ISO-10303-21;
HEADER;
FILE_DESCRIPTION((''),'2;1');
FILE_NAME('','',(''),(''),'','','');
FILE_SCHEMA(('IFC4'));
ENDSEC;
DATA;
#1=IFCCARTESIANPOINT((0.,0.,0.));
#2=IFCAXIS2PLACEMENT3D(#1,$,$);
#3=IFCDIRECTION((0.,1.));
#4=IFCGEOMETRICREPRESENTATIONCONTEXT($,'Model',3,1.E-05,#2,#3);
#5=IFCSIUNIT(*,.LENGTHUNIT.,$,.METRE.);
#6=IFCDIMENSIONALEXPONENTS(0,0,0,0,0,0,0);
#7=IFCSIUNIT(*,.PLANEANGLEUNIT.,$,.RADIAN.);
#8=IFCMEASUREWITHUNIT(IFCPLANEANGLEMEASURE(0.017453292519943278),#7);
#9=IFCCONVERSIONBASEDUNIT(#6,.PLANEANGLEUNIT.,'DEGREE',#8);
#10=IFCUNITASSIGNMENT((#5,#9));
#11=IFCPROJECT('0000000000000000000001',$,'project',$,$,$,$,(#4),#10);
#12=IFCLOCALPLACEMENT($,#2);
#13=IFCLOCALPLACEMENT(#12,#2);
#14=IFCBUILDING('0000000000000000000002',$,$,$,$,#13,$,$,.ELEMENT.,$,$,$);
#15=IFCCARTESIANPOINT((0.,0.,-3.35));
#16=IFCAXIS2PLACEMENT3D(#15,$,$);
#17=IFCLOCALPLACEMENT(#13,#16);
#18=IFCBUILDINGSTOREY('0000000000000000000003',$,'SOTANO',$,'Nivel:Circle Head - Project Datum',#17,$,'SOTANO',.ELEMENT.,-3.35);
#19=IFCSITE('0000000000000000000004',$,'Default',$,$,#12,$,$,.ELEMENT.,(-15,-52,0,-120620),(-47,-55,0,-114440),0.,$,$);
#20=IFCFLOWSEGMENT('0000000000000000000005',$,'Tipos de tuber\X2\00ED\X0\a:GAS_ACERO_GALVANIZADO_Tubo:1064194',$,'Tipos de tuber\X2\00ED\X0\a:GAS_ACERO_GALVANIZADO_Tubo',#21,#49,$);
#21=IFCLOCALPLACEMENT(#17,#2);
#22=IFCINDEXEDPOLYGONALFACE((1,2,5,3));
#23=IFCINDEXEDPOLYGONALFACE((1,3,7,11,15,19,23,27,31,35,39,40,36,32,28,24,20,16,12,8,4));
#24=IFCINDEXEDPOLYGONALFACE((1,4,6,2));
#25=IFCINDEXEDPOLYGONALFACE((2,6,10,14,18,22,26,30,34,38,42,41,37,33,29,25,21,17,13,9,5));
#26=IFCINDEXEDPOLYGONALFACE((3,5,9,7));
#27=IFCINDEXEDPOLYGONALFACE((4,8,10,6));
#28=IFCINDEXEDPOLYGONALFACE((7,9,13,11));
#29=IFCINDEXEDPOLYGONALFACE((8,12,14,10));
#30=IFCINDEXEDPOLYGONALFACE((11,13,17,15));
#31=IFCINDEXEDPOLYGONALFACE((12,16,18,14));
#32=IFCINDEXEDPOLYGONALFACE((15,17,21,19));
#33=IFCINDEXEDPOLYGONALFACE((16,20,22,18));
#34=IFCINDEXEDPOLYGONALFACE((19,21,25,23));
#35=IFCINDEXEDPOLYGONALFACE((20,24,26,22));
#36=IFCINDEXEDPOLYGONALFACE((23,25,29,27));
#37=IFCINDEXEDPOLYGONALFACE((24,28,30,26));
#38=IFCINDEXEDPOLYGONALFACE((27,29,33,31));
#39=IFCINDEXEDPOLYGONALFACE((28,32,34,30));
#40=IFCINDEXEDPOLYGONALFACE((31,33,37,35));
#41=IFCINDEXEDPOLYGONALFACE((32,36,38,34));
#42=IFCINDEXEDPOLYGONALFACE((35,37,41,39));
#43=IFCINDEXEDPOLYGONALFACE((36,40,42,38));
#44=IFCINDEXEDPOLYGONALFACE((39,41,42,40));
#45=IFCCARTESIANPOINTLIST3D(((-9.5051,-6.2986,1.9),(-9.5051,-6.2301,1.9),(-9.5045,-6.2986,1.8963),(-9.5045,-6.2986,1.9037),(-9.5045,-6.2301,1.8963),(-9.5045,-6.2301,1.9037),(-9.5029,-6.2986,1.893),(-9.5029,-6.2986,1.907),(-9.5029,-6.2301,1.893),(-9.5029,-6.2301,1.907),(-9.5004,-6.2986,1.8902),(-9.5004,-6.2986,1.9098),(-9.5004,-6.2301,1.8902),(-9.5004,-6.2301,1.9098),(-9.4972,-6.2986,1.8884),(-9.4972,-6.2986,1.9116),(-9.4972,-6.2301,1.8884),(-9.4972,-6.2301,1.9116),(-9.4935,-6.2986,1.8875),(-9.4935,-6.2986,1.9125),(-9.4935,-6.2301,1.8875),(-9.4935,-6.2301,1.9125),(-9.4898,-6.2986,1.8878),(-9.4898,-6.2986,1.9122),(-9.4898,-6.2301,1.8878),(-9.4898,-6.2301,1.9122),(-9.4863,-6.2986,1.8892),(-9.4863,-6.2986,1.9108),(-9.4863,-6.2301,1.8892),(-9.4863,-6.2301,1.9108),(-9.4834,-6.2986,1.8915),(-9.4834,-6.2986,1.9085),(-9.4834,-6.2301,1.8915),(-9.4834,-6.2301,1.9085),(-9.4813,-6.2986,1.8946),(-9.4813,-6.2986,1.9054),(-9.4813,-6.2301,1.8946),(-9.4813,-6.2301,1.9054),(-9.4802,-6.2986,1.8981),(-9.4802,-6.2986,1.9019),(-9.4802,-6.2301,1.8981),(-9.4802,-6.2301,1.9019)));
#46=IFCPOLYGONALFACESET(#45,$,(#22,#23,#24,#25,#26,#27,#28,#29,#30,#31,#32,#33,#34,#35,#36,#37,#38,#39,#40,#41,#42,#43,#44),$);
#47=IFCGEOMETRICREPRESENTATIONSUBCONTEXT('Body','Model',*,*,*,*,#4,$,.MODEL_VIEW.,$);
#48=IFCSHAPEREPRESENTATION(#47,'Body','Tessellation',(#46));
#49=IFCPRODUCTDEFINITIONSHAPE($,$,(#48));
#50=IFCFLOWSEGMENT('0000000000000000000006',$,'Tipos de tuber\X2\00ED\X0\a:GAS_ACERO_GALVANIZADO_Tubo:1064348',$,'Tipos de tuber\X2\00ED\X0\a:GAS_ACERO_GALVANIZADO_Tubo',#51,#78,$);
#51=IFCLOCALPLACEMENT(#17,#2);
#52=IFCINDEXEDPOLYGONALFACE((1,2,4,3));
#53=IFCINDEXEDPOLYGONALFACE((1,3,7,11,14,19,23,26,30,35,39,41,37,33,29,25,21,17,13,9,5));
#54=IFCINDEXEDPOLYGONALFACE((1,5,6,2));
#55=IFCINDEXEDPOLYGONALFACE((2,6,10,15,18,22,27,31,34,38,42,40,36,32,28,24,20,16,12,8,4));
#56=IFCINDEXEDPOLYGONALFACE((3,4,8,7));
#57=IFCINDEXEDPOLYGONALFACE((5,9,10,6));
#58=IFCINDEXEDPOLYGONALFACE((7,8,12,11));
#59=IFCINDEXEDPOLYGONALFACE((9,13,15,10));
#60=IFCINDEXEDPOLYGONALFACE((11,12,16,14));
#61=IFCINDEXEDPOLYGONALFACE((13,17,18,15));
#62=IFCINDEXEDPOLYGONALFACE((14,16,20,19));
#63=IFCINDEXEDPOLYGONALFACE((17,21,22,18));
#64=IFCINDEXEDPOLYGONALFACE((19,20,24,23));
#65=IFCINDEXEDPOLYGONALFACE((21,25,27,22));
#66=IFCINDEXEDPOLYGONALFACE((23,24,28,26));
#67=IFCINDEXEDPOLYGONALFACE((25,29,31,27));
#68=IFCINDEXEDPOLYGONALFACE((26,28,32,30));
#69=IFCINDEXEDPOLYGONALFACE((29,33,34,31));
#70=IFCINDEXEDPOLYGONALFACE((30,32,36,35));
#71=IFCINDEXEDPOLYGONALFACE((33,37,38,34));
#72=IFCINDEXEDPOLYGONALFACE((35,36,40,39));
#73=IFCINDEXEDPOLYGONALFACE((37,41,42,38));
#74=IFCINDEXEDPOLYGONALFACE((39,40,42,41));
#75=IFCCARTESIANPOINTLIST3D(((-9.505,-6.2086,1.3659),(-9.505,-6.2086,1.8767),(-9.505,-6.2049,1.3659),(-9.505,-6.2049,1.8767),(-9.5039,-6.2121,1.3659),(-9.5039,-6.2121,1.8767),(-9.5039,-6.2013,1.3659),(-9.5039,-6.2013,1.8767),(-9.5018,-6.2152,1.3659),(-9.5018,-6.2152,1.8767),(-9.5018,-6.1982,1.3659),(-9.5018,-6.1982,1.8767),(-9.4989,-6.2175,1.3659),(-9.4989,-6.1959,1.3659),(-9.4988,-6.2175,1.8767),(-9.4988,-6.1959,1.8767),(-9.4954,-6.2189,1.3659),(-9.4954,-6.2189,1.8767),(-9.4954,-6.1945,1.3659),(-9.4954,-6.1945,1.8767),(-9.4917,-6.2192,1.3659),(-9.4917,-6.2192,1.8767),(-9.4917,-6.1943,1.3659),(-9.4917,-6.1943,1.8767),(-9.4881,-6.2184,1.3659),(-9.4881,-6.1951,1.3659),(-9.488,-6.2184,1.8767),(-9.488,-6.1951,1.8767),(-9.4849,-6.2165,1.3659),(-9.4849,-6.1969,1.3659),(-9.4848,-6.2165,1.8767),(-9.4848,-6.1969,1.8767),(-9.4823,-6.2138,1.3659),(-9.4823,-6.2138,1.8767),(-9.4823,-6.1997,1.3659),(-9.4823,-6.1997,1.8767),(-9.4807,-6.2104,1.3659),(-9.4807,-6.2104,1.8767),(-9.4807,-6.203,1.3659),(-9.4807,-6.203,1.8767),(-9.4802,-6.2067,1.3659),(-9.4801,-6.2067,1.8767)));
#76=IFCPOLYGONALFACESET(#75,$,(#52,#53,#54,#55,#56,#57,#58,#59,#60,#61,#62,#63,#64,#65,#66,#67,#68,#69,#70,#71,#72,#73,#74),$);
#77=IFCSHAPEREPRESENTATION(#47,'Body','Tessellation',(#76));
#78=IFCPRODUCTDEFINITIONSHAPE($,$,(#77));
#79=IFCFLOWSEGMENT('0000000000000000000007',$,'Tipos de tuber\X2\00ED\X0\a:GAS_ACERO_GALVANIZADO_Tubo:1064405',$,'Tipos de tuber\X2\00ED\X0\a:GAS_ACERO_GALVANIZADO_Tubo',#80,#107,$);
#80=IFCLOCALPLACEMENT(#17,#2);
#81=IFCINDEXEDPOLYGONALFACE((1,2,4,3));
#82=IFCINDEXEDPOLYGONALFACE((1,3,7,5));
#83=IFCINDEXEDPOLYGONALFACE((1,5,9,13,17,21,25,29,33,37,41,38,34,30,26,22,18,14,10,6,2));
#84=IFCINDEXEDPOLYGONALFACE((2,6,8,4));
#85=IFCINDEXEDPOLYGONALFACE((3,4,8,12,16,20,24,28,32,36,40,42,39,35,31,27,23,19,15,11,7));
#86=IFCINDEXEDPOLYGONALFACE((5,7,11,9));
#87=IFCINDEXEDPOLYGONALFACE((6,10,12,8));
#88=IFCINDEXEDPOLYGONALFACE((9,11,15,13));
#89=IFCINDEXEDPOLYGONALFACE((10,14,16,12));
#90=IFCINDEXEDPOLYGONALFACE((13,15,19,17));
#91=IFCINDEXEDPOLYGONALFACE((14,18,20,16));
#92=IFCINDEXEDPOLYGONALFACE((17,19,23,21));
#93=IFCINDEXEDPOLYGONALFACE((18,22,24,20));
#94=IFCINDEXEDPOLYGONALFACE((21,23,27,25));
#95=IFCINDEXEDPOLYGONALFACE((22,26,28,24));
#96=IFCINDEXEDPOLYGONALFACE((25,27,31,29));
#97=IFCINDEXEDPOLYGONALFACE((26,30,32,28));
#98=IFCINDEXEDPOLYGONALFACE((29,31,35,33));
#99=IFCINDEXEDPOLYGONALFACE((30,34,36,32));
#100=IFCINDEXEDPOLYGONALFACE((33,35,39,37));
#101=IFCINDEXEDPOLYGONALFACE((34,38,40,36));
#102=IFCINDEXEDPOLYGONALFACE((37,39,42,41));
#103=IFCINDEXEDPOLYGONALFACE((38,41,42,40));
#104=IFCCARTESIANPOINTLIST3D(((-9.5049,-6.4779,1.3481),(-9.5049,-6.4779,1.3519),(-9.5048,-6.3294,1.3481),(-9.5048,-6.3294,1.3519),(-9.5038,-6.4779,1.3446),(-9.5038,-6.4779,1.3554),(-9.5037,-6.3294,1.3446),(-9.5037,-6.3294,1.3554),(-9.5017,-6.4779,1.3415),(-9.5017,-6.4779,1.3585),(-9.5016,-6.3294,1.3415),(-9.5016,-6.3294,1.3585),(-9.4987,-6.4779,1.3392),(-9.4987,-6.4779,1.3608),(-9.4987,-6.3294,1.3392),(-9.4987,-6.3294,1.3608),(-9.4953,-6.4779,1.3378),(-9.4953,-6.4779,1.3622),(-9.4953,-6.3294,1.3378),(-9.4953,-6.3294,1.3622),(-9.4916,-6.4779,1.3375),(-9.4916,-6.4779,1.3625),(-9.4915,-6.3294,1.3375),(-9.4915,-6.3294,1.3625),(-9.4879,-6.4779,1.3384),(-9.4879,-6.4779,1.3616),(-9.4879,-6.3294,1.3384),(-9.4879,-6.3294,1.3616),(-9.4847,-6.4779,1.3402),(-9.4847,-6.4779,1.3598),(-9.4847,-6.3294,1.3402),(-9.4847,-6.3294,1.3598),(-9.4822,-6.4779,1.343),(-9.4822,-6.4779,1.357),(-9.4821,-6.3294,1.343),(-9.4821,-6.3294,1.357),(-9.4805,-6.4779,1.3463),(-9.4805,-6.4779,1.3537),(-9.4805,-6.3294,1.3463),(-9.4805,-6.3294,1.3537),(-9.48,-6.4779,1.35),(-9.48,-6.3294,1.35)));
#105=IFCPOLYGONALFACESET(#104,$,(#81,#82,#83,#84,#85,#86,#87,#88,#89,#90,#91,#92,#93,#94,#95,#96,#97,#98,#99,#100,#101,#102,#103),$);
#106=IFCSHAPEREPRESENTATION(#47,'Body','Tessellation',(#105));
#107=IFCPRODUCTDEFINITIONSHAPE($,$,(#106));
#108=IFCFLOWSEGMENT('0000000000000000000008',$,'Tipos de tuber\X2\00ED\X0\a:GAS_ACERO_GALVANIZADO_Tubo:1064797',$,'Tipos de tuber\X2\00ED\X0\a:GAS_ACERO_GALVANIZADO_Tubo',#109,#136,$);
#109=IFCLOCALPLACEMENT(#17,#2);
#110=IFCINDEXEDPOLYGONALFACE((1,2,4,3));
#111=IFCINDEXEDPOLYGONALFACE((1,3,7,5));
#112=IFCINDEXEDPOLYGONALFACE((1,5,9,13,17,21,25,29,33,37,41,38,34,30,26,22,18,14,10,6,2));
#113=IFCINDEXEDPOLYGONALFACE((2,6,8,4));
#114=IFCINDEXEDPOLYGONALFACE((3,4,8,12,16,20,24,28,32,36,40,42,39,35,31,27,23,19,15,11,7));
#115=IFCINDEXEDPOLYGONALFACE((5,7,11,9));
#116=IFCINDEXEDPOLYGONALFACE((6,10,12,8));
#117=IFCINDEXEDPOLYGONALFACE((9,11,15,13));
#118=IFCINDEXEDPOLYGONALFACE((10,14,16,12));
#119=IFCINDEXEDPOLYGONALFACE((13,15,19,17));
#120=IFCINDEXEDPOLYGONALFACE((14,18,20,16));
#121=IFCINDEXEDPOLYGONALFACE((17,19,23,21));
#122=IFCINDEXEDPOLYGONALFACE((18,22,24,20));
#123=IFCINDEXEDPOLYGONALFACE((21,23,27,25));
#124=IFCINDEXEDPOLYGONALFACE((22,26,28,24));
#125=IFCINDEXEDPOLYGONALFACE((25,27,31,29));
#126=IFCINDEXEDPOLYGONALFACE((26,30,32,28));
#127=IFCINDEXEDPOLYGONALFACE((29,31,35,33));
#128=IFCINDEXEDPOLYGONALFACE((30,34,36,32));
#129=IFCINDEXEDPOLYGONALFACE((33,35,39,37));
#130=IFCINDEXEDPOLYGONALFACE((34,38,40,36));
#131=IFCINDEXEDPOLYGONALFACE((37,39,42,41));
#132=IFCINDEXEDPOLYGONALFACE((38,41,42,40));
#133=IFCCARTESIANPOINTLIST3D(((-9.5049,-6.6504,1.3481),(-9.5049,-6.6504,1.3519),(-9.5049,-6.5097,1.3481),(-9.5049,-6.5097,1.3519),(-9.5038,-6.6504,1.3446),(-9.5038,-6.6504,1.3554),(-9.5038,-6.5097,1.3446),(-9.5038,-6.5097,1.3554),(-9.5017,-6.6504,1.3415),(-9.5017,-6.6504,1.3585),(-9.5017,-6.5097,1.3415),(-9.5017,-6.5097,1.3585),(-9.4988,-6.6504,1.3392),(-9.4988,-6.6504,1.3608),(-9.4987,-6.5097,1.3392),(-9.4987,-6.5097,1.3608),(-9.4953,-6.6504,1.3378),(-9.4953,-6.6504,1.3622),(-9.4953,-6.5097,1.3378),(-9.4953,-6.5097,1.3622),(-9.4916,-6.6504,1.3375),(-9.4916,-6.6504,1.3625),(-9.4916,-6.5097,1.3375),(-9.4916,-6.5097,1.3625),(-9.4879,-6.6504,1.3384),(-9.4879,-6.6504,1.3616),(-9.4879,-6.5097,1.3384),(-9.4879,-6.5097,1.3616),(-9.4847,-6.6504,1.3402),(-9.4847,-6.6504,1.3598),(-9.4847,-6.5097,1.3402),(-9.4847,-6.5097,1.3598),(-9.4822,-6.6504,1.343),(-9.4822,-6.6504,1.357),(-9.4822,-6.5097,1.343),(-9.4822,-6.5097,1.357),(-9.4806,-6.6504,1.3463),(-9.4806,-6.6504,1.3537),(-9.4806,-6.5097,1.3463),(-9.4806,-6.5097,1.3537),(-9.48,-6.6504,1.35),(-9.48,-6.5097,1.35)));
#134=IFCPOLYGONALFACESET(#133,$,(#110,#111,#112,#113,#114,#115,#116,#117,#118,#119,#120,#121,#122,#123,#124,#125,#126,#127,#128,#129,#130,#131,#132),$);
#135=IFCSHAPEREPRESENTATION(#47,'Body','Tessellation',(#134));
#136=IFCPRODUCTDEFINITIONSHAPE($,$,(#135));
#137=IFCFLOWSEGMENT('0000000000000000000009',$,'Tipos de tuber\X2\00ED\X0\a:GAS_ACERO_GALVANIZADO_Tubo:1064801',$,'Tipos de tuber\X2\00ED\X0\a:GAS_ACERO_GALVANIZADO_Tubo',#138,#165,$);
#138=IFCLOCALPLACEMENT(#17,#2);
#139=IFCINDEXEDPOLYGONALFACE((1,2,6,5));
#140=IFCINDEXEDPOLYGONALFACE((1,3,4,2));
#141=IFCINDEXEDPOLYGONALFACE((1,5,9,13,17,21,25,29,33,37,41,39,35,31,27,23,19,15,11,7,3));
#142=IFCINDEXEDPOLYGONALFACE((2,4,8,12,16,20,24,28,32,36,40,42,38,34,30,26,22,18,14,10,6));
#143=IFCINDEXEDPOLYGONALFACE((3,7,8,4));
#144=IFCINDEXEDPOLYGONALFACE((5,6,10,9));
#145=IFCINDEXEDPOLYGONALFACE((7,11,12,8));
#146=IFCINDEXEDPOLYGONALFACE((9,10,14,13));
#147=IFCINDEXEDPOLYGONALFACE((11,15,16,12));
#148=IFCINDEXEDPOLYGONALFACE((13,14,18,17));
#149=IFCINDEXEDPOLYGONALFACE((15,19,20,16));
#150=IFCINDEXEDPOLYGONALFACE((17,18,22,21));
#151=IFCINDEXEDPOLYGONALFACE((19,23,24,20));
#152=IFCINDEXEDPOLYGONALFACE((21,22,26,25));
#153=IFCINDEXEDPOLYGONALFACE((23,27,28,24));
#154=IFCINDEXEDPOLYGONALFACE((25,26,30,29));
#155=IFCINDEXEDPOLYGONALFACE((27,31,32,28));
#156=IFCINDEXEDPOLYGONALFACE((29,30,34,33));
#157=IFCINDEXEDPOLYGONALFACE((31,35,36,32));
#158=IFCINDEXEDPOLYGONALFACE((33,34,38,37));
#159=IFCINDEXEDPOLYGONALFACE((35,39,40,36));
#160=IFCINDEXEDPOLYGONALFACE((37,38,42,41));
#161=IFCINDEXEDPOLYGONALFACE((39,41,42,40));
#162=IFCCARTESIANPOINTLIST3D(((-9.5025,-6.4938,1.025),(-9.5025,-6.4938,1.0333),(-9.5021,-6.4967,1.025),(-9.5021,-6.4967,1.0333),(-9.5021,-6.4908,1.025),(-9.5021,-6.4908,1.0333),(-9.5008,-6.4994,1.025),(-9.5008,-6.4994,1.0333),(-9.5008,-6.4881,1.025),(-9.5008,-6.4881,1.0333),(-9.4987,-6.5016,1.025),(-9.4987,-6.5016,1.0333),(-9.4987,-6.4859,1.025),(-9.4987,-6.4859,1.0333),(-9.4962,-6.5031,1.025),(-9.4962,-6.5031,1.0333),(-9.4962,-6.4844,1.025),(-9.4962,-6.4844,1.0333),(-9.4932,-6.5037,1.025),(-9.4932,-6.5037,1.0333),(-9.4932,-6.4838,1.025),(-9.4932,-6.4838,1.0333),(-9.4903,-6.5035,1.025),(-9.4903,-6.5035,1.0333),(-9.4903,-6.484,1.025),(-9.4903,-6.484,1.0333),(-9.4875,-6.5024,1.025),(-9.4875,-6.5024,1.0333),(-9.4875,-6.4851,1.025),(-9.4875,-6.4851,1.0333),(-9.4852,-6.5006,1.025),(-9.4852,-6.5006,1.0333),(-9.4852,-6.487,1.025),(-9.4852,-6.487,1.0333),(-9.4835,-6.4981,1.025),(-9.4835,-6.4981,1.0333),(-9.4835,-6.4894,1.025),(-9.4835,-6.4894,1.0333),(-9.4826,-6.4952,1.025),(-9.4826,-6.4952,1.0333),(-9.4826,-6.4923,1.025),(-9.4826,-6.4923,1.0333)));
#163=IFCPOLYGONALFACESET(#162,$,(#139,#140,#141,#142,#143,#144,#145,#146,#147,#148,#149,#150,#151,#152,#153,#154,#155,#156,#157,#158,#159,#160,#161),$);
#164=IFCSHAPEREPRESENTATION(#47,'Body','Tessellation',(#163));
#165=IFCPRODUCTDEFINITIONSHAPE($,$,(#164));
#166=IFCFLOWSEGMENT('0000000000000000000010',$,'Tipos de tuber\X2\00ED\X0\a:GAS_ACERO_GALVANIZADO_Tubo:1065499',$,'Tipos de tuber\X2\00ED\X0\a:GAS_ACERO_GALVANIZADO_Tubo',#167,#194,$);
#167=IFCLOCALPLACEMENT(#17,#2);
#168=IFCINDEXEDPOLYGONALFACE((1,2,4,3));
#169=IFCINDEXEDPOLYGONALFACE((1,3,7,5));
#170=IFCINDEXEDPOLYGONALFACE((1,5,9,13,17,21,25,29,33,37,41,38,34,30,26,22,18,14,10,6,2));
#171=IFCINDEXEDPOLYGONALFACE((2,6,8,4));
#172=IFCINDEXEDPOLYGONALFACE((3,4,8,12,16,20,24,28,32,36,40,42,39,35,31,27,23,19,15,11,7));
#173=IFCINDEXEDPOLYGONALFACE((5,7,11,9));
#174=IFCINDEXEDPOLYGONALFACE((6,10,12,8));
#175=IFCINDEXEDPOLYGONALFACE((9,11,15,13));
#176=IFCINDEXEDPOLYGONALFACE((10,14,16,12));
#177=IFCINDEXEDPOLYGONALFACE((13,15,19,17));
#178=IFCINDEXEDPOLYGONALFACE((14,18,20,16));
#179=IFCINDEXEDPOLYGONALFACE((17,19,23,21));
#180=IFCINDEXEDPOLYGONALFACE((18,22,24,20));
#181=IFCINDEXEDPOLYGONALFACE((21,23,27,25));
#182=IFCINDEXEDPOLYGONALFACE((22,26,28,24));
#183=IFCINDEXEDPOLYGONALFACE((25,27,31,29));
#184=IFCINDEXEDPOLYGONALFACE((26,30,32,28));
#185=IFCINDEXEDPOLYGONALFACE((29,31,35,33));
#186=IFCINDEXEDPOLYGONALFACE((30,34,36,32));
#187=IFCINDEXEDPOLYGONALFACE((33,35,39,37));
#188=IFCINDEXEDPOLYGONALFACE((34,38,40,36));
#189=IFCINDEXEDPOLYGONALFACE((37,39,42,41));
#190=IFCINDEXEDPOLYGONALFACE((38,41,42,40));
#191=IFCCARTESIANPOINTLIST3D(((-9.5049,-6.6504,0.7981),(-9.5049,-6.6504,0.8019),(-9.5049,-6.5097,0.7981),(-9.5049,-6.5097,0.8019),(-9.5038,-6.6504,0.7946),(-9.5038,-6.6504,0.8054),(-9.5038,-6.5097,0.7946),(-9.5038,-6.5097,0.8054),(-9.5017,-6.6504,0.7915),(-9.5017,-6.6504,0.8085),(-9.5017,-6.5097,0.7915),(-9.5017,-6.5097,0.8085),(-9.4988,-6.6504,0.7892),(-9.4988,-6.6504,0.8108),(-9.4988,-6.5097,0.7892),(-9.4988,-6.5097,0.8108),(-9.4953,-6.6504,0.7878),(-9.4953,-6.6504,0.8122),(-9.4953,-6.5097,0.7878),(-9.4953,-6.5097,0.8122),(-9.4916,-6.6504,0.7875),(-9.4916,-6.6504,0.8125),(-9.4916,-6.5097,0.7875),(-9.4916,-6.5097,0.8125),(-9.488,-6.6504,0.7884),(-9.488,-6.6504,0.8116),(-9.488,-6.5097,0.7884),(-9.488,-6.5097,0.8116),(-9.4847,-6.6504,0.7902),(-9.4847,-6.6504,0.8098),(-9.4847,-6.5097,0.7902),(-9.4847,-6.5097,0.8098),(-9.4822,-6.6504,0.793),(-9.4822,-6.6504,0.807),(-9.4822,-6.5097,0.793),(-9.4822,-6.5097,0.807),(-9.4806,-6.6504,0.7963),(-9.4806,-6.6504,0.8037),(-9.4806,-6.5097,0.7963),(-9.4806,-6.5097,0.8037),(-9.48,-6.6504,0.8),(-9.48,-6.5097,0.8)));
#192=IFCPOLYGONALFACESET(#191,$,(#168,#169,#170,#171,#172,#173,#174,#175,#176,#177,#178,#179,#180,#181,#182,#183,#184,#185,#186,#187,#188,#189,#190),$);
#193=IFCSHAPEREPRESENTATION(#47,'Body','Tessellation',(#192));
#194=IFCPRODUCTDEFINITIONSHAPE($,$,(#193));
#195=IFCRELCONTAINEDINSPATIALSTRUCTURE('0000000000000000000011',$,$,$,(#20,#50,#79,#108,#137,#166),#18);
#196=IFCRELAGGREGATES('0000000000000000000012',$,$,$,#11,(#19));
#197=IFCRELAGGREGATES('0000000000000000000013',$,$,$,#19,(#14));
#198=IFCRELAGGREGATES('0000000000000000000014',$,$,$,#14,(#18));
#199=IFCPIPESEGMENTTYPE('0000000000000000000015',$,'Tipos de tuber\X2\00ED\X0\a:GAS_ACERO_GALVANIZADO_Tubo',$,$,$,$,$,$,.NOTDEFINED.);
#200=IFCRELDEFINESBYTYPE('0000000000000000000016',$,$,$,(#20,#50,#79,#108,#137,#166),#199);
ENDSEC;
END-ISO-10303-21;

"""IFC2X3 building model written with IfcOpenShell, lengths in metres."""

from ifc_helpers import new_model, entity, si_unit, converted_unit, direction, frame, frame_2d, origin, origin_2d_with_axis, place, context, subcontext, project, spatial, circle, extrude, type_object, element, save


model = new_model("IFC2X3")

# Units and contexts
model_context = context("Model", 3, precision=1e-05, world=origin(), true_north=direction((0.0, 1.0)))
body_context = subcontext(model_context, "Body", "Model", "MODEL_VIEW")
ifc_project = project(units=[si_unit("LENGTHUNIT", "METRE"), converted_unit("PLANEANGLEUNIT", "DEGREE", entity("IfcPlaneAngleMeasure", 0.017453292519943278), si_unit("PLANEANGLEUNIT", "RADIAN"), dimensions=[0, 0, 0, 0, 0, 0, 0])], contexts=[model_context])

# Site, building, storey
site_placement = place(None, origin())
site = spatial("IfcSite", under=ifc_project, at=site_placement, Name="Default", CompositionType="ELEMENT", RefLatitude=(-15, -52, 0, -120620), RefLongitude=(-47, -55, 0, -114440), RefElevation=0.0)
building_placement = place(site_placement, origin())
building = spatial("IfcBuilding", under=site, at=building_placement, CompositionType="ELEMENT")
storey_placement = place(building_placement, frame((0.0, 0.0, -3.35)))
storey = spatial("IfcBuildingStorey", under=building, at=storey_placement, Name="SOTANO", ObjectType="Nivel:Circle Head - Project Datum", LongName="SOTANO", CompositionType="ELEMENT", Elevation=-3.35)

# Flow segments
pipe_segment_type_1 = type_object("IfcPipeSegmentType", Name="Tipos de tubería:GAS_ACERO_GALVANIZADO_Tubo", PredefinedType="NOTDEFINED")
flow_segment_1_placement = place(storey_placement, origin())
element("IfcFlowSegment", 1, at=flow_segment_1_placement, inside=storey, type_object=pipe_segment_type_1, Name="Tipos de tubería:GAS_ACERO_GALVANIZADO_Tubo:1064194", ObjectType="Tipos de tubería:GAS_ACERO_GALVANIZADO_Tubo", context=body_context, shape_type="SweptSolid", body=[
    extrude(circle(Radius=0.0125, at=origin_2d_with_axis()), frame((-9.4926, -6.2986, 1.9), z_axis=(0.000008, 1.0, 0.0), x_axis=(-1.0, 0.000008, 0.0)), (0.0, 0.0, 1.0), 0.0685),
])
flow_segment_2_placement = place(storey_placement, origin())
element("IfcFlowSegment", 2, at=flow_segment_2_placement, inside=storey, type_object=pipe_segment_type_1, Name="Tipos de tubería:GAS_ACERO_GALVANIZADO_Tubo:1064348", ObjectType="Tipos de tubería:GAS_ACERO_GALVANIZADO_Tubo", context=body_context, shape_type="SweptSolid", body=[
    extrude(circle(Radius=0.0125, at=frame_2d((0.0, 0.0), x_axis=(1.0, 0.0))), frame((-9.4927, -6.2067, 1.3659), z_axis=(0.000119, 0.0, 1.0), x_axis=(1.0, 0.0, -0.000119)), (0.0, 0.0, 1.0), 0.5108),
])
flow_segment_3_placement = place(storey_placement, origin())
element("IfcFlowSegment", 3, at=flow_segment_3_placement, inside=storey, type_object=pipe_segment_type_1, Name="Tipos de tubería:GAS_ACERO_GALVANIZADO_Tubo:1064405", ObjectType="Tipos de tubería:GAS_ACERO_GALVANIZADO_Tubo", context=body_context, shape_type="SweptSolid", body=[
    extrude(circle(Radius=0.0125, at=frame_2d((0.0, 0.0), x_axis=(1.0, 0.0))), frame((-9.4925, -6.4779, 1.35), z_axis=(0.00012, 1.0, 0.0), x_axis=(1.0, -0.00012, 0.0)), (0.0, 0.0, 1.0), 0.1485),
])
flow_segment_4_placement = place(storey_placement, origin())
element("IfcFlowSegment", 4, at=flow_segment_4_placement, inside=storey, type_object=pipe_segment_type_1, Name="Tipos de tubería:GAS_ACERO_GALVANIZADO_Tubo:1064797", ObjectType="Tipos de tubería:GAS_ACERO_GALVANIZADO_Tubo", context=body_context, shape_type="SweptSolid", body=[
    extrude(circle(Radius=0.0125, at=origin_2d_with_axis()), frame((-9.4925, -6.6504, 1.35), z_axis=(0.00012, 1.0, 0.0), x_axis=(1.0, -0.00012, 0.0)), (0.0, 0.0, 1.0), 0.1408),
])
flow_segment_5_placement = place(storey_placement, origin())
element("IfcFlowSegment", 5, at=flow_segment_5_placement, inside=storey, type_object=pipe_segment_type_1, Name="Tipos de tubería:GAS_ACERO_GALVANIZADO_Tubo:1064801", ObjectType="Tipos de tubería:GAS_ACERO_GALVANIZADO_Tubo", context=body_context, shape_type="SweptSolid", body=[
    extrude(circle(Radius=0.01, at=origin_2d_with_axis()), frame((-9.4925, -6.4938, 1.025), z_axis=(0.0, 0.0, 1.0), x_axis=(-1.0, 0.0, 0.0)), (0.0, 0.0, 1.0), 0.0083),
])
flow_segment_6_placement = place(storey_placement, origin())
element("IfcFlowSegment", 6, at=flow_segment_6_placement, inside=storey, type_object=pipe_segment_type_1, Name="Tipos de tubería:GAS_ACERO_GALVANIZADO_Tubo:1065499", ObjectType="Tipos de tubería:GAS_ACERO_GALVANIZADO_Tubo", context=body_context, shape_type="SweptSolid", body=[
    extrude(circle(Radius=0.0125, at=origin_2d_with_axis()), frame((-9.4925, -6.6504, 0.8), z_axis=(0.0, 1.0, 0.0), x_axis=(1.0, 0.0, 0.0)), (0.0, 0.0, 1.0), 0.1408),
])

save(model, "model.ifc")
